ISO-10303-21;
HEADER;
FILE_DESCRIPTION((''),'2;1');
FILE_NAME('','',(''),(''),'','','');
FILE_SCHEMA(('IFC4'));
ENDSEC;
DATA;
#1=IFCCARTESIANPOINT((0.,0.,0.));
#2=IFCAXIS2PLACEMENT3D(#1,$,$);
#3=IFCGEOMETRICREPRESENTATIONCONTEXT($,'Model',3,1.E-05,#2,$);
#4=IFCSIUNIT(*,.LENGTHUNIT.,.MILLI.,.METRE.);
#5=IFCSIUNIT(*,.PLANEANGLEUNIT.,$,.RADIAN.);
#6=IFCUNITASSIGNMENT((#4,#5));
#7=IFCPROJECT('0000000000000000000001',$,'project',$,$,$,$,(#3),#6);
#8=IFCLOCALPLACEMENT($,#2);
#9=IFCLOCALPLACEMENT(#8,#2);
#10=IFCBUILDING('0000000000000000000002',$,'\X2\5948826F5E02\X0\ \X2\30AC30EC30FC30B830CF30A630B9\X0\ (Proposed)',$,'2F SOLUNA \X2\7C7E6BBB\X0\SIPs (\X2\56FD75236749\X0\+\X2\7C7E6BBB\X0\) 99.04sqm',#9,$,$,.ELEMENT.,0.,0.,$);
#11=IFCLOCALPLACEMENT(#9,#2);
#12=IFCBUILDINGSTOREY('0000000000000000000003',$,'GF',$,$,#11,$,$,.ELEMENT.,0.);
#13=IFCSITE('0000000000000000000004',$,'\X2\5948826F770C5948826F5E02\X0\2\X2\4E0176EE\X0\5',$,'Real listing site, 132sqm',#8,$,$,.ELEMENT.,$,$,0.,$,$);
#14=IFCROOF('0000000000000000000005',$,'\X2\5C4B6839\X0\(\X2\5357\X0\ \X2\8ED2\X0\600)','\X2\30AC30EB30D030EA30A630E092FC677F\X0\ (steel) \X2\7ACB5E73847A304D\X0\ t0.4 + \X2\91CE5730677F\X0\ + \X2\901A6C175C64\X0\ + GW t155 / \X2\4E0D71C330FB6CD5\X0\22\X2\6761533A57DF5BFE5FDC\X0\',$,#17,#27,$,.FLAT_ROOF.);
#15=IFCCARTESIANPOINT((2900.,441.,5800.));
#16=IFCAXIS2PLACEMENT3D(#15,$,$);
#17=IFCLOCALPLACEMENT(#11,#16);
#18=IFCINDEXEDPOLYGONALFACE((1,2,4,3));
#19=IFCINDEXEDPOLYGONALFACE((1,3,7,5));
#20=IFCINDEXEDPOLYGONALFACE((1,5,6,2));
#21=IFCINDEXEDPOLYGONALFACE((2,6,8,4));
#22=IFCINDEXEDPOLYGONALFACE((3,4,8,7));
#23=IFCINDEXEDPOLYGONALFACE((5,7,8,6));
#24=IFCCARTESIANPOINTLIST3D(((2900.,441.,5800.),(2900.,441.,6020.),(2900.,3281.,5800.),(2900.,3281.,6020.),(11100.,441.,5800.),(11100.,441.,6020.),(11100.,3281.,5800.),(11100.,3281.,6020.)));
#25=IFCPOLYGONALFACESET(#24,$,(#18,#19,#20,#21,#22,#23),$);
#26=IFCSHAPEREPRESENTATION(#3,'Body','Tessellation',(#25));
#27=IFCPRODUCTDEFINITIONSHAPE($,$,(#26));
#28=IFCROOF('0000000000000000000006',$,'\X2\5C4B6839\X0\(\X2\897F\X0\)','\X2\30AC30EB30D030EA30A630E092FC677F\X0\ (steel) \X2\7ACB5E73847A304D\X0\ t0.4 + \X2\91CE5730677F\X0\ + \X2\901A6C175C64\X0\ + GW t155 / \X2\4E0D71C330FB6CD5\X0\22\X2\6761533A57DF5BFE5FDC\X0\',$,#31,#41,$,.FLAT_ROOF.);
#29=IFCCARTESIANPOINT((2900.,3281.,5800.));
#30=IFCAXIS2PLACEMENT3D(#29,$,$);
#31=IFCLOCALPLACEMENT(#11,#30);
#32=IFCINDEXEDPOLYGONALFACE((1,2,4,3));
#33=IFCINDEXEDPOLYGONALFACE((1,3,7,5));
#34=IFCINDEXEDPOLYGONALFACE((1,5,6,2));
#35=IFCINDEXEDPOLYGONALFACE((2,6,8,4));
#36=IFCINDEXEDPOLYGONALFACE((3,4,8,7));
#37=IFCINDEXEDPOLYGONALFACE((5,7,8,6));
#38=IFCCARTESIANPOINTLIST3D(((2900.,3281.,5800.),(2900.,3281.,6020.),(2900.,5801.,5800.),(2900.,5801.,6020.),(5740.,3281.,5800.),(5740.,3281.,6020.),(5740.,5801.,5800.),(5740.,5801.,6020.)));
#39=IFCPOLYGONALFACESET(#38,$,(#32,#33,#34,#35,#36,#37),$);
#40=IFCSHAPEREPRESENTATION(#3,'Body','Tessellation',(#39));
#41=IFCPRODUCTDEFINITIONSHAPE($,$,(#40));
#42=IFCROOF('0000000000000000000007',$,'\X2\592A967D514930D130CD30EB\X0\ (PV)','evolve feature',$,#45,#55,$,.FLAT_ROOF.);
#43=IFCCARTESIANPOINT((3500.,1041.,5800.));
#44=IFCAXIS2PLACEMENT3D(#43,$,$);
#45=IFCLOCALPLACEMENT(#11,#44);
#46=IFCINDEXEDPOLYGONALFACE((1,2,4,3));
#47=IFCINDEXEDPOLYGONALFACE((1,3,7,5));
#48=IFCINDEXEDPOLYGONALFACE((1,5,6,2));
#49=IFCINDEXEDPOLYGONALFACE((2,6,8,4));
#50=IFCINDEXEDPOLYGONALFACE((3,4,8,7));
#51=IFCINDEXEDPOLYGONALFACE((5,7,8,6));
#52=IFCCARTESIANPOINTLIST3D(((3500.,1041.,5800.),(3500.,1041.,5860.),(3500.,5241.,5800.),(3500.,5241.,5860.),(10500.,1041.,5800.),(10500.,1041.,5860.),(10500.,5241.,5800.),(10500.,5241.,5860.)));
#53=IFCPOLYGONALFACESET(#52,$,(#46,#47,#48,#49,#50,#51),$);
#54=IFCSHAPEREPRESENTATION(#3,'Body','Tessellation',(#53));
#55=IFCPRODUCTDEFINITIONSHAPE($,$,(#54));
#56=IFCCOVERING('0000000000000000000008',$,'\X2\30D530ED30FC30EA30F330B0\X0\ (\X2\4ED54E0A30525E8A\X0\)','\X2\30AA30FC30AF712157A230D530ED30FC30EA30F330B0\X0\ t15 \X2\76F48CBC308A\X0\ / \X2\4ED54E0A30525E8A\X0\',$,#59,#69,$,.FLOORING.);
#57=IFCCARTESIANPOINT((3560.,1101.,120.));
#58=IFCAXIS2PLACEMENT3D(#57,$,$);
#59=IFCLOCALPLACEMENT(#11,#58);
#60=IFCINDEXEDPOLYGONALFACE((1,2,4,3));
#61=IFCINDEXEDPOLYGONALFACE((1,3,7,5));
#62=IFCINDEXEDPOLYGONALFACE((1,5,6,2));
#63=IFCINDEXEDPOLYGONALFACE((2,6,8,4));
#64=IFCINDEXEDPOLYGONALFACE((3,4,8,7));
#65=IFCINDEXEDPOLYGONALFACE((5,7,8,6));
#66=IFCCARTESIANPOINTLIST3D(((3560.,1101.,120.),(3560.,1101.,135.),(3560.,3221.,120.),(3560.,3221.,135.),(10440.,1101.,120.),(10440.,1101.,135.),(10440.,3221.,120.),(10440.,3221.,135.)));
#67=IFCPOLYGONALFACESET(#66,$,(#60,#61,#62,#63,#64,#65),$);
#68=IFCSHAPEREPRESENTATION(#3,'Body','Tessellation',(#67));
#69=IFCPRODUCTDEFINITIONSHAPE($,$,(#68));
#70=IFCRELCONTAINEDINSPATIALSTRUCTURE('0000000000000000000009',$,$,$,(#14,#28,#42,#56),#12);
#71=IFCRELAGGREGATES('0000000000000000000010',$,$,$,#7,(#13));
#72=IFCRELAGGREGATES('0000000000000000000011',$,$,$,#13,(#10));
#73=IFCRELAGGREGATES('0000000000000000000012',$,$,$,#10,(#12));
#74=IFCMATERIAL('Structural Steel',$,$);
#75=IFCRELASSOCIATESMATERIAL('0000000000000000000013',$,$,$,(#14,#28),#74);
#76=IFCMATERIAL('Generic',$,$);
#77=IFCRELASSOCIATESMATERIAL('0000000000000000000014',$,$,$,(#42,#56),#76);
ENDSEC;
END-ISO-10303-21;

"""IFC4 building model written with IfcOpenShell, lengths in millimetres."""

from ifc_helpers import new_model, si_unit, frame, frame_2d, origin, place, context, project, spatial, rectangle, extrude, material, element, save


model = new_model("IFC4")

# Units and contexts
model_context = context("Model", 3, precision=1e-05, world=origin())
ifc_project = project(units=[si_unit("LENGTHUNIT", "METRE", prefix="MILLI"), si_unit("PLANEANGLEUNIT", "RADIAN")], contexts=[model_context])

# Site, building, storey
site_placement = place(None, origin())
site = spatial("IfcSite", under=ifc_project, at=site_placement, Name="奈良県奈良市2丁目5", ObjectType="Real listing site, 132sqm", CompositionType="ELEMENT", RefElevation=0.0)
building_placement = place(site_placement, origin())
building = spatial("IfcBuilding", under=site, at=building_placement, Name="奈良市 ガレージハウス (Proposed)", ObjectType="2F SOLUNA 籾殻SIPs (国産杉+籾殻) 99.04sqm", CompositionType="ELEMENT", ElevationOfRefHeight=0.0, ElevationOfTerrain=0.0)
storey_placement = place(building_placement, origin())
storey = spatial("IfcBuildingStorey", under=building, at=storey_placement, Name="GF", CompositionType="ELEMENT", Elevation=0.0)

# Shared definitions
ifc_material_1 = material(Name="Generic")

# Roofs
ifc_material_2 = material(Name="Structural Steel")
roof_1_placement = place(storey_placement, frame((2900.0, 441.0, 5800.0)))
element("IfcRoof", 1, at=roof_1_placement, inside=storey, material=ifc_material_2, Name="屋根(南 軒600)", Description="ガルバリウム鋼板 (steel) 立平葺き t0.4 + 野地板 + 通気層 + GW t155 / 不燃・法22条区域対応", PredefinedType="FLAT_ROOF", context=model_context, shape_type="SweptSolid", body=[
    extrude(rectangle(XDim=8200.0, YDim=2840.0, at=frame_2d((4100.0, 1420.0))), frame((2900.0, 441.0, 5800.0)), (0.0, 0.0, 1.0), 220.0),
])
roof_2_placement = place(storey_placement, frame((2900.0, 3281.0, 5800.0)))
element("IfcRoof", 2, at=roof_2_placement, inside=storey, material=ifc_material_2, Name="屋根(西)", Description="ガルバリウム鋼板 (steel) 立平葺き t0.4 + 野地板 + 通気層 + GW t155 / 不燃・法22条区域対応", PredefinedType="FLAT_ROOF", context=model_context, shape_type="SweptSolid", body=[
    extrude(rectangle(XDim=2840.0, YDim=2520.0, at=frame_2d((1420.0, 1260.0))), frame((2900.0, 3281.0, 5800.0)), (0.0, 0.0, 1.0), 220.0),
])
roof_3_placement = place(storey_placement, frame((3500.0, 1041.0, 5800.0)))
element("IfcRoof", 3, at=roof_3_placement, inside=storey, material=ifc_material_1, Name="太陽光パネル (PV)", Description="evolve feature", PredefinedType="FLAT_ROOF", context=model_context, shape_type="SweptSolid", body=[
    extrude(rectangle(XDim=7000.0, YDim=4200.0, at=frame_2d((3500.0, 2100.0))), frame((3500.0, 1041.0, 5800.0)), (0.0, 0.0, 1.0), 60.0),
])

# Covering
covering_placement = place(storey_placement, frame((3560.0, 1101.0, 120.0)))
element("IfcCovering", 4, at=covering_placement, inside=storey, material=ifc_material_1, Name="フローリング (仕上げ床)", Description="オーク無垢フローリング t15 直貼り / 仕上げ床", PredefinedType="FLOORING", context=model_context, shape_type="SweptSolid", body=[
    extrude(rectangle(XDim=6880.0, YDim=2120.0, at=frame_2d((3440.0, 1060.0))), frame((3560.0, 1101.0, 120.0)), (0.0, 0.0, 1.0), 15.0),
])

save(model, "model.ifc")
